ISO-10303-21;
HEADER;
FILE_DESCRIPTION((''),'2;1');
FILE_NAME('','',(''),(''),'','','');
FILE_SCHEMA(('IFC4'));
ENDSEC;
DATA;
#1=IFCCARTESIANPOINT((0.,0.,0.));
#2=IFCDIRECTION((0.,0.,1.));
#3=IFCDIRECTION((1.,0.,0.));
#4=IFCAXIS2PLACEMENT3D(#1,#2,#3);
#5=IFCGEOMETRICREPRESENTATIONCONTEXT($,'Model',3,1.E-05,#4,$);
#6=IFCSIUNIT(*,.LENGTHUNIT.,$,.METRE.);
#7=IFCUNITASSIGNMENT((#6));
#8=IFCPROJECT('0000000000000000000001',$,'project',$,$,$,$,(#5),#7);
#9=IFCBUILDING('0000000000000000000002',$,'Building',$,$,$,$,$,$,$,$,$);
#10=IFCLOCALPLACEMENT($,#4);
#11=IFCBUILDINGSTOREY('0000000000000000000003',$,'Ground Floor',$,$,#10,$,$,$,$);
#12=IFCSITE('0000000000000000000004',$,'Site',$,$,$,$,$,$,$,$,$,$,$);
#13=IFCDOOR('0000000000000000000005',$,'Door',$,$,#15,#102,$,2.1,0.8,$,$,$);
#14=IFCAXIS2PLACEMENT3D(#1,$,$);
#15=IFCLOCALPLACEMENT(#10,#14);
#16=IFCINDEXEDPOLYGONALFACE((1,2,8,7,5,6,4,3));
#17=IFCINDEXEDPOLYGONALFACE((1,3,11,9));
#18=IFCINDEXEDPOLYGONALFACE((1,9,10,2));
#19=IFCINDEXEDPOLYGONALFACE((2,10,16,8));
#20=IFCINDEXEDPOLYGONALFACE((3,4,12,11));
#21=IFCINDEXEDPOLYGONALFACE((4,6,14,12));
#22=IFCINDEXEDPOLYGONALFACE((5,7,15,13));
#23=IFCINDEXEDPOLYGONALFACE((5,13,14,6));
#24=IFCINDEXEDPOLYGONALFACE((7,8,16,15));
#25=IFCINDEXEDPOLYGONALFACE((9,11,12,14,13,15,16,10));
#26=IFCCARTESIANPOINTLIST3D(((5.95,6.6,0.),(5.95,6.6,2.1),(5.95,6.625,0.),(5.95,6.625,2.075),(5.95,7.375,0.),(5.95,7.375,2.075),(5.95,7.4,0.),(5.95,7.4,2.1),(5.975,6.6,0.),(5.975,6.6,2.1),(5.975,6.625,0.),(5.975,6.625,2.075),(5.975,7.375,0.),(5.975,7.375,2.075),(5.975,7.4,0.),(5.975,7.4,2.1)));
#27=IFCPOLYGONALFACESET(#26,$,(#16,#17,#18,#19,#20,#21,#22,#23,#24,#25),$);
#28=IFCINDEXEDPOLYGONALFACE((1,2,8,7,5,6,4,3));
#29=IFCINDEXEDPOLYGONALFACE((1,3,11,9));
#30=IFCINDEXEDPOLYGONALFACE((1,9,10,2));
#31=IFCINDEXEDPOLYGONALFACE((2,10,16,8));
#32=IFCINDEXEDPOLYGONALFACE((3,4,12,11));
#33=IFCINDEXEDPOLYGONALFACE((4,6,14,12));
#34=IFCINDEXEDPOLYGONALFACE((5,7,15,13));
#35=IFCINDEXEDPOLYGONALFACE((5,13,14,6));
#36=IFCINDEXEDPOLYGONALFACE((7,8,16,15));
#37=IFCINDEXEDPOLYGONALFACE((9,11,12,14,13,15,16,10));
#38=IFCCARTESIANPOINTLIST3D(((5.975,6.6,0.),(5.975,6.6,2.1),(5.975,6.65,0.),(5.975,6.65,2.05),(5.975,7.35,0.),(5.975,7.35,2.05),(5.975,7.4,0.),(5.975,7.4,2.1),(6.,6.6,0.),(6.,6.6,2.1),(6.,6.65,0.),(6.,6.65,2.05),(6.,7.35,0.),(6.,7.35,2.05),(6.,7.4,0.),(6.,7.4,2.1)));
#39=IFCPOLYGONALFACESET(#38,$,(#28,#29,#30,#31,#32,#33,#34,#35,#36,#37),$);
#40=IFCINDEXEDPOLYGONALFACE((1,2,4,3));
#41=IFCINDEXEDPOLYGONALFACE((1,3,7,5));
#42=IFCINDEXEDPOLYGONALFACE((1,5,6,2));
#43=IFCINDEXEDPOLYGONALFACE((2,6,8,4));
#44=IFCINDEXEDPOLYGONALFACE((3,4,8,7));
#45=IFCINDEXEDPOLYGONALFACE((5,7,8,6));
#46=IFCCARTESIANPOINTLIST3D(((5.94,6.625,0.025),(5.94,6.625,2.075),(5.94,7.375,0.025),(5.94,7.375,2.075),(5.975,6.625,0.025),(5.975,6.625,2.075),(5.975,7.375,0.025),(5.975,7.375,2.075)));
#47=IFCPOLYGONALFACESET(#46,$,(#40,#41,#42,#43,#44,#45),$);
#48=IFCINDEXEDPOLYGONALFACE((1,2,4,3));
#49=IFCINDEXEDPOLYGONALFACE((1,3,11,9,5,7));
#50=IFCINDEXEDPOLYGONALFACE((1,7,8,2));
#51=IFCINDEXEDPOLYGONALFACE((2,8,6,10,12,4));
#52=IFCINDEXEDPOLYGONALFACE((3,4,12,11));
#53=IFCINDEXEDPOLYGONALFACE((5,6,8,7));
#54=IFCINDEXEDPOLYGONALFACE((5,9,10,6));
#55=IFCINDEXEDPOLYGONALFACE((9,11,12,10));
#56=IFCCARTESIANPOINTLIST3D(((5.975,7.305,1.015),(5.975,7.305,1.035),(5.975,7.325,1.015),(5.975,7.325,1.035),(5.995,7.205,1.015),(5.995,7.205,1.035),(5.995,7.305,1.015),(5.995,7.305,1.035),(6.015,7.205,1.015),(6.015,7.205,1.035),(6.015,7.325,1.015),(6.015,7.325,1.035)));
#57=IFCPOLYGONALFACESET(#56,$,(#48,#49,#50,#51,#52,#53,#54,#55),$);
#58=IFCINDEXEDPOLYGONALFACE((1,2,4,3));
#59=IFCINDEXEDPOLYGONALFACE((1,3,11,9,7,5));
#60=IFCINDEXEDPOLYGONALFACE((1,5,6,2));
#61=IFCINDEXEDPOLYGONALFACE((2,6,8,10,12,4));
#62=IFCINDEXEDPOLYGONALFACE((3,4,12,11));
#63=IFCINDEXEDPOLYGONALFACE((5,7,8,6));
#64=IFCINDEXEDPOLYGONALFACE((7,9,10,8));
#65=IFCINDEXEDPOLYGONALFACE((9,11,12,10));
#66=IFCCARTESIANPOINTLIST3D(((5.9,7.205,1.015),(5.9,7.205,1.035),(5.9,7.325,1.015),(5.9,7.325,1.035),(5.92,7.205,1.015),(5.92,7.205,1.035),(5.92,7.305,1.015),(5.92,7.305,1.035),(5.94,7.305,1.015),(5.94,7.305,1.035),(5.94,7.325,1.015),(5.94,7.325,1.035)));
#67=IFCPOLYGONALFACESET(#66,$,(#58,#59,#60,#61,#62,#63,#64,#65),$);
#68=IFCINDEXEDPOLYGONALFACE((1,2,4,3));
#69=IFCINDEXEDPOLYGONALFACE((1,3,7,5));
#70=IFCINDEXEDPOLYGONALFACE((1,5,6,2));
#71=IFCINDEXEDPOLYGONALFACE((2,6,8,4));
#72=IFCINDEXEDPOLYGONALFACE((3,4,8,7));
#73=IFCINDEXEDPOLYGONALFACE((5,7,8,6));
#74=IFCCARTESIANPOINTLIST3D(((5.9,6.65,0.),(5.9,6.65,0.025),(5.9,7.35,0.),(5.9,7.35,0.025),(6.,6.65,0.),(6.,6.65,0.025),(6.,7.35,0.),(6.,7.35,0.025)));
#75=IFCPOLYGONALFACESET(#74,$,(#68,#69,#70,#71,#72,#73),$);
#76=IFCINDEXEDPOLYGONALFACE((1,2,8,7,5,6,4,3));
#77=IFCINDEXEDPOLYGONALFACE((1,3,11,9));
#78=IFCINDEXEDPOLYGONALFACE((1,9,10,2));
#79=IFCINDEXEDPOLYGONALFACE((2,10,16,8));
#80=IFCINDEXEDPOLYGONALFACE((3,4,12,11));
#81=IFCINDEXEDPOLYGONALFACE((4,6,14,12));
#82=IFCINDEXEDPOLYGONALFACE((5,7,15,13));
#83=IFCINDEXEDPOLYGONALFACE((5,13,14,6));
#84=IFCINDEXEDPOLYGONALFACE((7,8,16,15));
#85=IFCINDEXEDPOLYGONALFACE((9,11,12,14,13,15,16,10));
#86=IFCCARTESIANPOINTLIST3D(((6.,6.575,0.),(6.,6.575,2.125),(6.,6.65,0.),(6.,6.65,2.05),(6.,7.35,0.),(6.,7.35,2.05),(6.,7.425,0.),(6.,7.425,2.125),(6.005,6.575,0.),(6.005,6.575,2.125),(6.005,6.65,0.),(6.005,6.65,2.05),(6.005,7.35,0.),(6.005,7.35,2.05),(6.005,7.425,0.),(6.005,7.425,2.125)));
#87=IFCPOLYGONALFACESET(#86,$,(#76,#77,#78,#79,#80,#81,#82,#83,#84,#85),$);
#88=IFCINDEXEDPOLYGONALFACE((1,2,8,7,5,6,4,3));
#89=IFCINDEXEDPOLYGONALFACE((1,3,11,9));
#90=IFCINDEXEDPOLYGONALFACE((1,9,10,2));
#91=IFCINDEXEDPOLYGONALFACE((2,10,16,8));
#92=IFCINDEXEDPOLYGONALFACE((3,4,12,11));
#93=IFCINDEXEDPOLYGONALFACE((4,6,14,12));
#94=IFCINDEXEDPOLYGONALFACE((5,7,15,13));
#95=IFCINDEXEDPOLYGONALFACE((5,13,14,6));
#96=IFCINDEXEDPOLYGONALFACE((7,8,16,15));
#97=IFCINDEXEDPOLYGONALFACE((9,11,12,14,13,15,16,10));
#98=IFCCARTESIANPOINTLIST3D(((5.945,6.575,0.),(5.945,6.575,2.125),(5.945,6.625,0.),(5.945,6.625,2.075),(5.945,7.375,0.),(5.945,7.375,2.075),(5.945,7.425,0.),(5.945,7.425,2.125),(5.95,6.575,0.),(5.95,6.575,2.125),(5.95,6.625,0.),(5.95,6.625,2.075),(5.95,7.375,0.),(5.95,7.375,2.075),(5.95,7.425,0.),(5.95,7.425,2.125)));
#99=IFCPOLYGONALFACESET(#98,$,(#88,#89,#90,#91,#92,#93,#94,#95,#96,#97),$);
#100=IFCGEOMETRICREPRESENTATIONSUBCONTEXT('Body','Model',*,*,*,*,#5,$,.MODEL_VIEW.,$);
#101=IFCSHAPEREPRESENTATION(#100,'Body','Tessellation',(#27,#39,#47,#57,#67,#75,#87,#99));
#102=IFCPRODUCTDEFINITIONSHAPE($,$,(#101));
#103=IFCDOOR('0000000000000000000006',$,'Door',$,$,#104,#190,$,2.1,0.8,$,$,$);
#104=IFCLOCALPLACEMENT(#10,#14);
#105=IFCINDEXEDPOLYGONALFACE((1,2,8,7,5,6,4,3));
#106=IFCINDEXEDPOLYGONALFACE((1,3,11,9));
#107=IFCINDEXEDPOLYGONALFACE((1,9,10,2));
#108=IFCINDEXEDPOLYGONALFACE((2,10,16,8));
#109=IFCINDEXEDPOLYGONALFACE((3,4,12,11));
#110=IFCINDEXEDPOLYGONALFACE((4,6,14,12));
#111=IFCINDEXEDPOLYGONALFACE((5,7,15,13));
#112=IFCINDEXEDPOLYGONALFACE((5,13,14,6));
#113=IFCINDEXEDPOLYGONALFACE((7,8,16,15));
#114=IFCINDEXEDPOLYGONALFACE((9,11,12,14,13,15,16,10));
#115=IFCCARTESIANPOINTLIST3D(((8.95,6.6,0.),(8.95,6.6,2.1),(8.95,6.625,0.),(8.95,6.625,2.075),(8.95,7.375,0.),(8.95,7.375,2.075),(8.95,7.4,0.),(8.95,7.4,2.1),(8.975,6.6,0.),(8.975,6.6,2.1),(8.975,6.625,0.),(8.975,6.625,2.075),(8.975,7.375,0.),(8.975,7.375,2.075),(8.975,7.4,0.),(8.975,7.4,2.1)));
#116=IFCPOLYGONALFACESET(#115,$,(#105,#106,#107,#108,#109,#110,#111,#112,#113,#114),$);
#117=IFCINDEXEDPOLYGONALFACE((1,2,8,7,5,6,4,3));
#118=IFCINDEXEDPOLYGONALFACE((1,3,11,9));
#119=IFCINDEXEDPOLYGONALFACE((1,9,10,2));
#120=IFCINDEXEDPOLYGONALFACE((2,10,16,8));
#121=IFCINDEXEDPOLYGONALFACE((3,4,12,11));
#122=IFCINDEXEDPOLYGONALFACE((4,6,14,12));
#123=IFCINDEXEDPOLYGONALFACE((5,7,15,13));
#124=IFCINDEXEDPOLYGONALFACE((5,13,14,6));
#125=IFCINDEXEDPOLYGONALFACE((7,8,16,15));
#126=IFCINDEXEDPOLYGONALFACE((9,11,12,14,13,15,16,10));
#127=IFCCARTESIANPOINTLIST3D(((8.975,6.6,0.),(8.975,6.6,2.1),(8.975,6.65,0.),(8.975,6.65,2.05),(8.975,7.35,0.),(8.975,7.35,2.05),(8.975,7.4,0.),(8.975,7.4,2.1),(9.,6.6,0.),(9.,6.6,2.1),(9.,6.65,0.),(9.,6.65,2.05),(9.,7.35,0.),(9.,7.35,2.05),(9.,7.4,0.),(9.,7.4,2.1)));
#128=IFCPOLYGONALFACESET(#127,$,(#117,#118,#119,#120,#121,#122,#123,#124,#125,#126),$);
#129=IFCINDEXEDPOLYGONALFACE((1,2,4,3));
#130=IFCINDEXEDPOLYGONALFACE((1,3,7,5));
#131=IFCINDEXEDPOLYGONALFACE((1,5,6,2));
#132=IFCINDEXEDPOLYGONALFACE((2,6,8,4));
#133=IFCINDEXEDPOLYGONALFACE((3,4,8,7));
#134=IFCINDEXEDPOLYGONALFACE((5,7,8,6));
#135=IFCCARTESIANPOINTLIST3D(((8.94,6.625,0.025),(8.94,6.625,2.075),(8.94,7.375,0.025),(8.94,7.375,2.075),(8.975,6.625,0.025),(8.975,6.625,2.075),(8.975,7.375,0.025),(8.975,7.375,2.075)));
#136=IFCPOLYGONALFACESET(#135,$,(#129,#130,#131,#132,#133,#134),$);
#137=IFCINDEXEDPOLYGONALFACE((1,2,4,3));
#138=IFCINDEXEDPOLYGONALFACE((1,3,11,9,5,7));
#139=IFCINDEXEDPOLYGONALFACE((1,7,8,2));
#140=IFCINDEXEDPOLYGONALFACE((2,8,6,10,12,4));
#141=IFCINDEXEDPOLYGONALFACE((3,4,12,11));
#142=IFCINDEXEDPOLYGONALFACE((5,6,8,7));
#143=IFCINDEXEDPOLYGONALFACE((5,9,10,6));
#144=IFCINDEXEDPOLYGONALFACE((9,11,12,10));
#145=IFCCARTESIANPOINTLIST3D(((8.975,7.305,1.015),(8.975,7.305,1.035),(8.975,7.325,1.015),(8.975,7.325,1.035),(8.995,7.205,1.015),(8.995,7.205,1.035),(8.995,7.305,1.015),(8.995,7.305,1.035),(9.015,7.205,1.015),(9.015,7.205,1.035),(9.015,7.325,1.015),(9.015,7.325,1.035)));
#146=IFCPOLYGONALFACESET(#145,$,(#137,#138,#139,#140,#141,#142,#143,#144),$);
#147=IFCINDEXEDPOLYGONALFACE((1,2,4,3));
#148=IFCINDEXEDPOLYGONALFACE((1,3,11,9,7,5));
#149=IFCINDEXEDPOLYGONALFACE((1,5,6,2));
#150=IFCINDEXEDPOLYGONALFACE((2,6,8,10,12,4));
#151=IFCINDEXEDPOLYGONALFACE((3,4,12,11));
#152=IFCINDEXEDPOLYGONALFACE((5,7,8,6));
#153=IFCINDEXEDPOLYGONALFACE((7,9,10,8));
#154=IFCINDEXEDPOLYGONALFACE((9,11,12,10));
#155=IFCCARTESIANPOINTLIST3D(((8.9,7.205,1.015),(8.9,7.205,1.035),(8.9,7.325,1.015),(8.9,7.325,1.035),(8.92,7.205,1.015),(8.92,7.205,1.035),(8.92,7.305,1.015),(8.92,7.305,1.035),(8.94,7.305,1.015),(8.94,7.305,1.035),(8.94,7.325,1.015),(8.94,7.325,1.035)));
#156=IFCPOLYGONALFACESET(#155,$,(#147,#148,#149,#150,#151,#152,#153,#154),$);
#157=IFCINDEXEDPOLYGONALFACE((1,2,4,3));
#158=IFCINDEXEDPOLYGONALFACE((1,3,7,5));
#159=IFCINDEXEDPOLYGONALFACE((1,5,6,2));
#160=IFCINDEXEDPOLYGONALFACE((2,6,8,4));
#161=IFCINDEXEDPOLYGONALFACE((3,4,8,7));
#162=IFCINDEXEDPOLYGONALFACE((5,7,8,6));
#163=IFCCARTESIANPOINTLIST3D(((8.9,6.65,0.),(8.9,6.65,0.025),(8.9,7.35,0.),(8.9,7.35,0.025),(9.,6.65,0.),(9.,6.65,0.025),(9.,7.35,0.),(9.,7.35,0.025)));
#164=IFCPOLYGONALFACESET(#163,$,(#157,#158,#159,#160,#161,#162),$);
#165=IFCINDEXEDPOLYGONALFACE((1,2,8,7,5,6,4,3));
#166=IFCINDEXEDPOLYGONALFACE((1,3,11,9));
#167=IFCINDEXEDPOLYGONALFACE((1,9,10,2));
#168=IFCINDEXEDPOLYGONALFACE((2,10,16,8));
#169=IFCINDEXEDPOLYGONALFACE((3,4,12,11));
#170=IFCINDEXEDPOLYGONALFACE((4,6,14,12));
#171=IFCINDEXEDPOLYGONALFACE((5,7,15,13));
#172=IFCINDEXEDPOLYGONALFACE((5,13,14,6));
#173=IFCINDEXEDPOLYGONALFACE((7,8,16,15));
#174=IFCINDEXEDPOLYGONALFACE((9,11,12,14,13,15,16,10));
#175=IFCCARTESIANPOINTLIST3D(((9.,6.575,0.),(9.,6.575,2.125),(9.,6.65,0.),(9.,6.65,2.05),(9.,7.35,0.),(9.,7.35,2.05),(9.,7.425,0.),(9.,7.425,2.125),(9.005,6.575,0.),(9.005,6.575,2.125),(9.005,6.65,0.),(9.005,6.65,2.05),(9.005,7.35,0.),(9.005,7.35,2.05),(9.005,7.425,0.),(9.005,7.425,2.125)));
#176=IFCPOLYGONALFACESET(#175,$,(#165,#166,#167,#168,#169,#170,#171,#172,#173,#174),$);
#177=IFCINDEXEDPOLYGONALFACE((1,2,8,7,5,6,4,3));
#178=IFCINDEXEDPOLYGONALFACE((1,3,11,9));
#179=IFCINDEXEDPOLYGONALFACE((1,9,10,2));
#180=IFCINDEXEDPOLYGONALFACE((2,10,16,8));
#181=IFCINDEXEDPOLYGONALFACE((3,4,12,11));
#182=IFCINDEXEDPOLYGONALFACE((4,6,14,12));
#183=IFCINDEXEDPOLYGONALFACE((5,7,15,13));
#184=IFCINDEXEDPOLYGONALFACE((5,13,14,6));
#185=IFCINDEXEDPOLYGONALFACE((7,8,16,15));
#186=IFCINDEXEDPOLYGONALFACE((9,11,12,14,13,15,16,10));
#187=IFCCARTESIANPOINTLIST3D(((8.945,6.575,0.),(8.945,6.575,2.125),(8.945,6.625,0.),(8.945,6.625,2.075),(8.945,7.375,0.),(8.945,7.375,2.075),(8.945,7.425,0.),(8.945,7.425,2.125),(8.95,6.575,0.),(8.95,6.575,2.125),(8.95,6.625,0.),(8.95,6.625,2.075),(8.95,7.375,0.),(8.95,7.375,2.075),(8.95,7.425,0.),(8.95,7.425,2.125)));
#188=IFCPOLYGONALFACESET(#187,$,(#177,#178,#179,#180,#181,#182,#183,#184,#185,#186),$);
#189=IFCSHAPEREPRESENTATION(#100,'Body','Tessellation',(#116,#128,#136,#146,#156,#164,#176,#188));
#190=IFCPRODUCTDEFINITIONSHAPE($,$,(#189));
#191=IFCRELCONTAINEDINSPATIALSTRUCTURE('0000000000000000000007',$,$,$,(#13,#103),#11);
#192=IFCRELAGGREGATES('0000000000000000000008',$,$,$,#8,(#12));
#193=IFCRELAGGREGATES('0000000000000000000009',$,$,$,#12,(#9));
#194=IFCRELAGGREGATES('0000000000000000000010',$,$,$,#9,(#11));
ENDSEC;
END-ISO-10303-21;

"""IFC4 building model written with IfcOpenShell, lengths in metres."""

from ifc_helpers import new_model, si_unit, frame, origin_with_axes, place, context, subcontext, project, spatial, line, indexed_curve, outline, extrude, element, save


model = new_model("IFC4")

# Units and contexts
model_context = context("Model", 3, precision=1e-05, world=origin_with_axes())
body_context = subcontext(model_context, "Body", "Model", "MODEL_VIEW")
ifc_project = project(units=[si_unit("LENGTHUNIT", "METRE")], contexts=[model_context])

# Site, building, storey
site = spatial("IfcSite", under=ifc_project, Name="Site")
building = spatial("IfcBuilding", under=site, Name="Building")
storey_placement = place(None, origin_with_axes())
storey = spatial("IfcBuildingStorey", under=building, at=storey_placement, Name="Ground Floor")

# Doors
door_1_placement = place(storey_placement, frame((6.0, 6.6, 0.0), z_axis=(0.0, 0.0, 1.0), x_axis=(0.0, 1.0, 0.0)))
element("IfcDoor", 1, at=door_1_placement, inside=storey, Name="Door", OverallHeight=2.1, OverallWidth=0.8, context=body_context, shape_type="SweptSolid", body=[
    extrude(outline(indexed_curve([(0.0, 0.0), (0.0, 2.1), (0.8, 2.1), (0.8, 0.0), (0.775, 0.0), (0.775, 2.075), (0.025, 2.075), (0.025, 0.0)], segments=[line(1, 2, 3, 4, 5, 6, 7, 8, 1)])), frame((0.0, 0.025, 0.0), z_axis=(0.0, -1.0, 0.0), x_axis=(1.0, 0.0, 0.0)), (0.0, 0.0, -1.0), 0.025),
    extrude(outline(indexed_curve([(0.0, 0.0), (0.0, 2.1), (0.8, 2.1), (0.8, 0.0), (0.75, 0.0), (0.75, 2.05), (0.05, 2.05), (0.05, 0.0)], segments=[line(1, 2, 3, 4, 5, 6, 7, 8, 1)])), frame((0.0, 0.0, 0.0), z_axis=(0.0, -1.0, 0.0), x_axis=(1.0, 0.0, 0.0)), (0.0, 0.0, -1.0), 0.025),
    extrude(outline(indexed_curve([(0.0, 0.0), (0.75, 0.0), (0.75, 0.035), (0.0, 0.035)], segments=[line(1, 2, 3, 4, 1)])), frame((0.025, 0.025, 0.025), z_axis=(0.0, 0.0, 1.0), x_axis=(1.0, 0.0, 0.0)), (0.0, 0.0, 1.0), 2.05),
    extrude(outline(indexed_curve([(0.0, 0.0), (0.0, -0.04), (-0.12, -0.04), (-0.12, -0.02), (-0.02, -0.02), (-0.02, 0.0)], segments=[line(1, 2, 3, 4, 5, 6, 1)])), frame((0.725, 0.025, 1.015), z_axis=(0.0, 0.0, 1.0), x_axis=(1.0, 0.0, 0.0)), (0.0, 0.0, 1.0), 0.02),
    extrude(outline(indexed_curve([(0.0, 0.0), (0.0, 0.04), (-0.12, 0.04), (-0.12, 0.02), (-0.02, 0.02), (-0.02, 0.0)], segments=[line(1, 2, 3, 4, 5, 6, 1)])), frame((0.725, 0.06, 1.015), z_axis=(0.0, 0.0, 1.0), x_axis=(1.0, 0.0, 0.0)), (0.0, 0.0, 1.0), 0.02),
    extrude(outline(indexed_curve([(0.0, 0.0), (0.7, 0.0), (0.7, 0.1), (0.0, 0.1)], segments=[line(1, 2, 3, 4, 1)])), frame((0.05, 0.0, 0.0), z_axis=(0.0, 0.0, 1.0), x_axis=(1.0, 0.0, 0.0)), (0.0, 0.0, 1.0), 0.025),
    extrude(outline(indexed_curve([(0.0, 0.0), (0.0, 2.125), (0.85, 2.125), (0.85, 0.0), (0.775, 0.0), (0.775, 2.05), (0.075, 2.05), (0.075, 0.0)], segments=[line(1, 2, 3, 4, 5, 6, 7, 8, 1)])), frame((-0.025, -0.005, 0.0), z_axis=(0.0, -1.0, 0.0), x_axis=(1.0, 0.0, 0.0)), (0.0, 0.0, -1.0), 0.005),
    extrude(outline(indexed_curve([(0.0, 0.0), (0.0, 2.125), (0.85, 2.125), (0.85, 0.0), (0.8, 0.0), (0.8, 2.075), (0.05, 2.075), (0.05, 0.0)], segments=[line(1, 2, 3, 4, 5, 6, 7, 8, 1)])), frame((-0.025, 0.05, 0.0), z_axis=(0.0, -1.0, 0.0), x_axis=(1.0, 0.0, 0.0)), (0.0, 0.0, -1.0), 0.005),
])
door_2_placement = place(storey_placement, frame((9.0, 6.6, 0.0), z_axis=(0.0, 0.0, 1.0), x_axis=(0.0, 1.0, 0.0)))
element("IfcDoor", 2, at=door_2_placement, inside=storey, Name="Door", OverallHeight=2.1, OverallWidth=0.8, context=body_context, shape_type="SweptSolid", body=[
    extrude(outline(indexed_curve([(0.0, 0.0), (0.0, 2.1), (0.8, 2.1), (0.8, 0.0), (0.775, 0.0), (0.775, 2.075), (0.025, 2.075), (0.025, 0.0)], segments=[line(1, 2, 3, 4, 5, 6, 7, 8, 1)])), frame((0.0, 0.025, 0.0), z_axis=(0.0, -1.0, 0.0), x_axis=(1.0, 0.0, 0.0)), (0.0, 0.0, -1.0), 0.025),
    extrude(outline(indexed_curve([(0.0, 0.0), (0.0, 2.1), (0.8, 2.1), (0.8, 0.0), (0.75, 0.0), (0.75, 2.05), (0.05, 2.05), (0.05, 0.0)], segments=[line(1, 2, 3, 4, 5, 6, 7, 8, 1)])), frame((0.0, 0.0, 0.0), z_axis=(0.0, -1.0, 0.0), x_axis=(1.0, 0.0, 0.0)), (0.0, 0.0, -1.0), 0.025),
    extrude(outline(indexed_curve([(0.0, 0.0), (0.75, 0.0), (0.75, 0.035), (0.0, 0.035)], segments=[line(1, 2, 3, 4, 1)])), frame((0.025, 0.025, 0.025), z_axis=(0.0, 0.0, 1.0), x_axis=(1.0, 0.0, 0.0)), (0.0, 0.0, 1.0), 2.05),
    extrude(outline(indexed_curve([(0.0, 0.0), (0.0, -0.04), (-0.12, -0.04), (-0.12, -0.02), (-0.02, -0.02), (-0.02, 0.0)], segments=[line(1, 2, 3, 4, 5, 6, 1)])), frame((0.725, 0.025, 1.015), z_axis=(0.0, 0.0, 1.0), x_axis=(1.0, 0.0, 0.0)), (0.0, 0.0, 1.0), 0.02),
    extrude(outline(indexed_curve([(0.0, 0.0), (0.0, 0.04), (-0.12, 0.04), (-0.12, 0.02), (-0.02, 0.02), (-0.02, 0.0)], segments=[line(1, 2, 3, 4, 5, 6, 1)])), frame((0.725, 0.06, 1.015), z_axis=(0.0, 0.0, 1.0), x_axis=(1.0, 0.0, 0.0)), (0.0, 0.0, 1.0), 0.02),
    extrude(outline(indexed_curve([(0.0, 0.0), (0.7, 0.0), (0.7, 0.1), (0.0, 0.1)], segments=[line(1, 2, 3, 4, 1)])), frame((0.05, 0.0, 0.0), z_axis=(0.0, 0.0, 1.0), x_axis=(1.0, 0.0, 0.0)), (0.0, 0.0, 1.0), 0.025),
    extrude(outline(indexed_curve([(0.0, 0.0), (0.0, 2.125), (0.85, 2.125), (0.85, 0.0), (0.775, 0.0), (0.775, 2.05), (0.075, 2.05), (0.075, 0.0)], segments=[line(1, 2, 3, 4, 5, 6, 7, 8, 1)])), frame((-0.025, -0.005, 0.0), z_axis=(0.0, -1.0, 0.0), x_axis=(1.0, 0.0, 0.0)), (0.0, 0.0, -1.0), 0.005),
    extrude(outline(indexed_curve([(0.0, 0.0), (0.0, 2.125), (0.85, 2.125), (0.85, 0.0), (0.8, 0.0), (0.8, 2.075), (0.05, 2.075), (0.05, 0.0)], segments=[line(1, 2, 3, 4, 5, 6, 7, 8, 1)])), frame((-0.025, 0.05, 0.0), z_axis=(0.0, -1.0, 0.0), x_axis=(1.0, 0.0, 0.0)), (0.0, 0.0, -1.0), 0.005),
])

save(model, "model.ifc")
